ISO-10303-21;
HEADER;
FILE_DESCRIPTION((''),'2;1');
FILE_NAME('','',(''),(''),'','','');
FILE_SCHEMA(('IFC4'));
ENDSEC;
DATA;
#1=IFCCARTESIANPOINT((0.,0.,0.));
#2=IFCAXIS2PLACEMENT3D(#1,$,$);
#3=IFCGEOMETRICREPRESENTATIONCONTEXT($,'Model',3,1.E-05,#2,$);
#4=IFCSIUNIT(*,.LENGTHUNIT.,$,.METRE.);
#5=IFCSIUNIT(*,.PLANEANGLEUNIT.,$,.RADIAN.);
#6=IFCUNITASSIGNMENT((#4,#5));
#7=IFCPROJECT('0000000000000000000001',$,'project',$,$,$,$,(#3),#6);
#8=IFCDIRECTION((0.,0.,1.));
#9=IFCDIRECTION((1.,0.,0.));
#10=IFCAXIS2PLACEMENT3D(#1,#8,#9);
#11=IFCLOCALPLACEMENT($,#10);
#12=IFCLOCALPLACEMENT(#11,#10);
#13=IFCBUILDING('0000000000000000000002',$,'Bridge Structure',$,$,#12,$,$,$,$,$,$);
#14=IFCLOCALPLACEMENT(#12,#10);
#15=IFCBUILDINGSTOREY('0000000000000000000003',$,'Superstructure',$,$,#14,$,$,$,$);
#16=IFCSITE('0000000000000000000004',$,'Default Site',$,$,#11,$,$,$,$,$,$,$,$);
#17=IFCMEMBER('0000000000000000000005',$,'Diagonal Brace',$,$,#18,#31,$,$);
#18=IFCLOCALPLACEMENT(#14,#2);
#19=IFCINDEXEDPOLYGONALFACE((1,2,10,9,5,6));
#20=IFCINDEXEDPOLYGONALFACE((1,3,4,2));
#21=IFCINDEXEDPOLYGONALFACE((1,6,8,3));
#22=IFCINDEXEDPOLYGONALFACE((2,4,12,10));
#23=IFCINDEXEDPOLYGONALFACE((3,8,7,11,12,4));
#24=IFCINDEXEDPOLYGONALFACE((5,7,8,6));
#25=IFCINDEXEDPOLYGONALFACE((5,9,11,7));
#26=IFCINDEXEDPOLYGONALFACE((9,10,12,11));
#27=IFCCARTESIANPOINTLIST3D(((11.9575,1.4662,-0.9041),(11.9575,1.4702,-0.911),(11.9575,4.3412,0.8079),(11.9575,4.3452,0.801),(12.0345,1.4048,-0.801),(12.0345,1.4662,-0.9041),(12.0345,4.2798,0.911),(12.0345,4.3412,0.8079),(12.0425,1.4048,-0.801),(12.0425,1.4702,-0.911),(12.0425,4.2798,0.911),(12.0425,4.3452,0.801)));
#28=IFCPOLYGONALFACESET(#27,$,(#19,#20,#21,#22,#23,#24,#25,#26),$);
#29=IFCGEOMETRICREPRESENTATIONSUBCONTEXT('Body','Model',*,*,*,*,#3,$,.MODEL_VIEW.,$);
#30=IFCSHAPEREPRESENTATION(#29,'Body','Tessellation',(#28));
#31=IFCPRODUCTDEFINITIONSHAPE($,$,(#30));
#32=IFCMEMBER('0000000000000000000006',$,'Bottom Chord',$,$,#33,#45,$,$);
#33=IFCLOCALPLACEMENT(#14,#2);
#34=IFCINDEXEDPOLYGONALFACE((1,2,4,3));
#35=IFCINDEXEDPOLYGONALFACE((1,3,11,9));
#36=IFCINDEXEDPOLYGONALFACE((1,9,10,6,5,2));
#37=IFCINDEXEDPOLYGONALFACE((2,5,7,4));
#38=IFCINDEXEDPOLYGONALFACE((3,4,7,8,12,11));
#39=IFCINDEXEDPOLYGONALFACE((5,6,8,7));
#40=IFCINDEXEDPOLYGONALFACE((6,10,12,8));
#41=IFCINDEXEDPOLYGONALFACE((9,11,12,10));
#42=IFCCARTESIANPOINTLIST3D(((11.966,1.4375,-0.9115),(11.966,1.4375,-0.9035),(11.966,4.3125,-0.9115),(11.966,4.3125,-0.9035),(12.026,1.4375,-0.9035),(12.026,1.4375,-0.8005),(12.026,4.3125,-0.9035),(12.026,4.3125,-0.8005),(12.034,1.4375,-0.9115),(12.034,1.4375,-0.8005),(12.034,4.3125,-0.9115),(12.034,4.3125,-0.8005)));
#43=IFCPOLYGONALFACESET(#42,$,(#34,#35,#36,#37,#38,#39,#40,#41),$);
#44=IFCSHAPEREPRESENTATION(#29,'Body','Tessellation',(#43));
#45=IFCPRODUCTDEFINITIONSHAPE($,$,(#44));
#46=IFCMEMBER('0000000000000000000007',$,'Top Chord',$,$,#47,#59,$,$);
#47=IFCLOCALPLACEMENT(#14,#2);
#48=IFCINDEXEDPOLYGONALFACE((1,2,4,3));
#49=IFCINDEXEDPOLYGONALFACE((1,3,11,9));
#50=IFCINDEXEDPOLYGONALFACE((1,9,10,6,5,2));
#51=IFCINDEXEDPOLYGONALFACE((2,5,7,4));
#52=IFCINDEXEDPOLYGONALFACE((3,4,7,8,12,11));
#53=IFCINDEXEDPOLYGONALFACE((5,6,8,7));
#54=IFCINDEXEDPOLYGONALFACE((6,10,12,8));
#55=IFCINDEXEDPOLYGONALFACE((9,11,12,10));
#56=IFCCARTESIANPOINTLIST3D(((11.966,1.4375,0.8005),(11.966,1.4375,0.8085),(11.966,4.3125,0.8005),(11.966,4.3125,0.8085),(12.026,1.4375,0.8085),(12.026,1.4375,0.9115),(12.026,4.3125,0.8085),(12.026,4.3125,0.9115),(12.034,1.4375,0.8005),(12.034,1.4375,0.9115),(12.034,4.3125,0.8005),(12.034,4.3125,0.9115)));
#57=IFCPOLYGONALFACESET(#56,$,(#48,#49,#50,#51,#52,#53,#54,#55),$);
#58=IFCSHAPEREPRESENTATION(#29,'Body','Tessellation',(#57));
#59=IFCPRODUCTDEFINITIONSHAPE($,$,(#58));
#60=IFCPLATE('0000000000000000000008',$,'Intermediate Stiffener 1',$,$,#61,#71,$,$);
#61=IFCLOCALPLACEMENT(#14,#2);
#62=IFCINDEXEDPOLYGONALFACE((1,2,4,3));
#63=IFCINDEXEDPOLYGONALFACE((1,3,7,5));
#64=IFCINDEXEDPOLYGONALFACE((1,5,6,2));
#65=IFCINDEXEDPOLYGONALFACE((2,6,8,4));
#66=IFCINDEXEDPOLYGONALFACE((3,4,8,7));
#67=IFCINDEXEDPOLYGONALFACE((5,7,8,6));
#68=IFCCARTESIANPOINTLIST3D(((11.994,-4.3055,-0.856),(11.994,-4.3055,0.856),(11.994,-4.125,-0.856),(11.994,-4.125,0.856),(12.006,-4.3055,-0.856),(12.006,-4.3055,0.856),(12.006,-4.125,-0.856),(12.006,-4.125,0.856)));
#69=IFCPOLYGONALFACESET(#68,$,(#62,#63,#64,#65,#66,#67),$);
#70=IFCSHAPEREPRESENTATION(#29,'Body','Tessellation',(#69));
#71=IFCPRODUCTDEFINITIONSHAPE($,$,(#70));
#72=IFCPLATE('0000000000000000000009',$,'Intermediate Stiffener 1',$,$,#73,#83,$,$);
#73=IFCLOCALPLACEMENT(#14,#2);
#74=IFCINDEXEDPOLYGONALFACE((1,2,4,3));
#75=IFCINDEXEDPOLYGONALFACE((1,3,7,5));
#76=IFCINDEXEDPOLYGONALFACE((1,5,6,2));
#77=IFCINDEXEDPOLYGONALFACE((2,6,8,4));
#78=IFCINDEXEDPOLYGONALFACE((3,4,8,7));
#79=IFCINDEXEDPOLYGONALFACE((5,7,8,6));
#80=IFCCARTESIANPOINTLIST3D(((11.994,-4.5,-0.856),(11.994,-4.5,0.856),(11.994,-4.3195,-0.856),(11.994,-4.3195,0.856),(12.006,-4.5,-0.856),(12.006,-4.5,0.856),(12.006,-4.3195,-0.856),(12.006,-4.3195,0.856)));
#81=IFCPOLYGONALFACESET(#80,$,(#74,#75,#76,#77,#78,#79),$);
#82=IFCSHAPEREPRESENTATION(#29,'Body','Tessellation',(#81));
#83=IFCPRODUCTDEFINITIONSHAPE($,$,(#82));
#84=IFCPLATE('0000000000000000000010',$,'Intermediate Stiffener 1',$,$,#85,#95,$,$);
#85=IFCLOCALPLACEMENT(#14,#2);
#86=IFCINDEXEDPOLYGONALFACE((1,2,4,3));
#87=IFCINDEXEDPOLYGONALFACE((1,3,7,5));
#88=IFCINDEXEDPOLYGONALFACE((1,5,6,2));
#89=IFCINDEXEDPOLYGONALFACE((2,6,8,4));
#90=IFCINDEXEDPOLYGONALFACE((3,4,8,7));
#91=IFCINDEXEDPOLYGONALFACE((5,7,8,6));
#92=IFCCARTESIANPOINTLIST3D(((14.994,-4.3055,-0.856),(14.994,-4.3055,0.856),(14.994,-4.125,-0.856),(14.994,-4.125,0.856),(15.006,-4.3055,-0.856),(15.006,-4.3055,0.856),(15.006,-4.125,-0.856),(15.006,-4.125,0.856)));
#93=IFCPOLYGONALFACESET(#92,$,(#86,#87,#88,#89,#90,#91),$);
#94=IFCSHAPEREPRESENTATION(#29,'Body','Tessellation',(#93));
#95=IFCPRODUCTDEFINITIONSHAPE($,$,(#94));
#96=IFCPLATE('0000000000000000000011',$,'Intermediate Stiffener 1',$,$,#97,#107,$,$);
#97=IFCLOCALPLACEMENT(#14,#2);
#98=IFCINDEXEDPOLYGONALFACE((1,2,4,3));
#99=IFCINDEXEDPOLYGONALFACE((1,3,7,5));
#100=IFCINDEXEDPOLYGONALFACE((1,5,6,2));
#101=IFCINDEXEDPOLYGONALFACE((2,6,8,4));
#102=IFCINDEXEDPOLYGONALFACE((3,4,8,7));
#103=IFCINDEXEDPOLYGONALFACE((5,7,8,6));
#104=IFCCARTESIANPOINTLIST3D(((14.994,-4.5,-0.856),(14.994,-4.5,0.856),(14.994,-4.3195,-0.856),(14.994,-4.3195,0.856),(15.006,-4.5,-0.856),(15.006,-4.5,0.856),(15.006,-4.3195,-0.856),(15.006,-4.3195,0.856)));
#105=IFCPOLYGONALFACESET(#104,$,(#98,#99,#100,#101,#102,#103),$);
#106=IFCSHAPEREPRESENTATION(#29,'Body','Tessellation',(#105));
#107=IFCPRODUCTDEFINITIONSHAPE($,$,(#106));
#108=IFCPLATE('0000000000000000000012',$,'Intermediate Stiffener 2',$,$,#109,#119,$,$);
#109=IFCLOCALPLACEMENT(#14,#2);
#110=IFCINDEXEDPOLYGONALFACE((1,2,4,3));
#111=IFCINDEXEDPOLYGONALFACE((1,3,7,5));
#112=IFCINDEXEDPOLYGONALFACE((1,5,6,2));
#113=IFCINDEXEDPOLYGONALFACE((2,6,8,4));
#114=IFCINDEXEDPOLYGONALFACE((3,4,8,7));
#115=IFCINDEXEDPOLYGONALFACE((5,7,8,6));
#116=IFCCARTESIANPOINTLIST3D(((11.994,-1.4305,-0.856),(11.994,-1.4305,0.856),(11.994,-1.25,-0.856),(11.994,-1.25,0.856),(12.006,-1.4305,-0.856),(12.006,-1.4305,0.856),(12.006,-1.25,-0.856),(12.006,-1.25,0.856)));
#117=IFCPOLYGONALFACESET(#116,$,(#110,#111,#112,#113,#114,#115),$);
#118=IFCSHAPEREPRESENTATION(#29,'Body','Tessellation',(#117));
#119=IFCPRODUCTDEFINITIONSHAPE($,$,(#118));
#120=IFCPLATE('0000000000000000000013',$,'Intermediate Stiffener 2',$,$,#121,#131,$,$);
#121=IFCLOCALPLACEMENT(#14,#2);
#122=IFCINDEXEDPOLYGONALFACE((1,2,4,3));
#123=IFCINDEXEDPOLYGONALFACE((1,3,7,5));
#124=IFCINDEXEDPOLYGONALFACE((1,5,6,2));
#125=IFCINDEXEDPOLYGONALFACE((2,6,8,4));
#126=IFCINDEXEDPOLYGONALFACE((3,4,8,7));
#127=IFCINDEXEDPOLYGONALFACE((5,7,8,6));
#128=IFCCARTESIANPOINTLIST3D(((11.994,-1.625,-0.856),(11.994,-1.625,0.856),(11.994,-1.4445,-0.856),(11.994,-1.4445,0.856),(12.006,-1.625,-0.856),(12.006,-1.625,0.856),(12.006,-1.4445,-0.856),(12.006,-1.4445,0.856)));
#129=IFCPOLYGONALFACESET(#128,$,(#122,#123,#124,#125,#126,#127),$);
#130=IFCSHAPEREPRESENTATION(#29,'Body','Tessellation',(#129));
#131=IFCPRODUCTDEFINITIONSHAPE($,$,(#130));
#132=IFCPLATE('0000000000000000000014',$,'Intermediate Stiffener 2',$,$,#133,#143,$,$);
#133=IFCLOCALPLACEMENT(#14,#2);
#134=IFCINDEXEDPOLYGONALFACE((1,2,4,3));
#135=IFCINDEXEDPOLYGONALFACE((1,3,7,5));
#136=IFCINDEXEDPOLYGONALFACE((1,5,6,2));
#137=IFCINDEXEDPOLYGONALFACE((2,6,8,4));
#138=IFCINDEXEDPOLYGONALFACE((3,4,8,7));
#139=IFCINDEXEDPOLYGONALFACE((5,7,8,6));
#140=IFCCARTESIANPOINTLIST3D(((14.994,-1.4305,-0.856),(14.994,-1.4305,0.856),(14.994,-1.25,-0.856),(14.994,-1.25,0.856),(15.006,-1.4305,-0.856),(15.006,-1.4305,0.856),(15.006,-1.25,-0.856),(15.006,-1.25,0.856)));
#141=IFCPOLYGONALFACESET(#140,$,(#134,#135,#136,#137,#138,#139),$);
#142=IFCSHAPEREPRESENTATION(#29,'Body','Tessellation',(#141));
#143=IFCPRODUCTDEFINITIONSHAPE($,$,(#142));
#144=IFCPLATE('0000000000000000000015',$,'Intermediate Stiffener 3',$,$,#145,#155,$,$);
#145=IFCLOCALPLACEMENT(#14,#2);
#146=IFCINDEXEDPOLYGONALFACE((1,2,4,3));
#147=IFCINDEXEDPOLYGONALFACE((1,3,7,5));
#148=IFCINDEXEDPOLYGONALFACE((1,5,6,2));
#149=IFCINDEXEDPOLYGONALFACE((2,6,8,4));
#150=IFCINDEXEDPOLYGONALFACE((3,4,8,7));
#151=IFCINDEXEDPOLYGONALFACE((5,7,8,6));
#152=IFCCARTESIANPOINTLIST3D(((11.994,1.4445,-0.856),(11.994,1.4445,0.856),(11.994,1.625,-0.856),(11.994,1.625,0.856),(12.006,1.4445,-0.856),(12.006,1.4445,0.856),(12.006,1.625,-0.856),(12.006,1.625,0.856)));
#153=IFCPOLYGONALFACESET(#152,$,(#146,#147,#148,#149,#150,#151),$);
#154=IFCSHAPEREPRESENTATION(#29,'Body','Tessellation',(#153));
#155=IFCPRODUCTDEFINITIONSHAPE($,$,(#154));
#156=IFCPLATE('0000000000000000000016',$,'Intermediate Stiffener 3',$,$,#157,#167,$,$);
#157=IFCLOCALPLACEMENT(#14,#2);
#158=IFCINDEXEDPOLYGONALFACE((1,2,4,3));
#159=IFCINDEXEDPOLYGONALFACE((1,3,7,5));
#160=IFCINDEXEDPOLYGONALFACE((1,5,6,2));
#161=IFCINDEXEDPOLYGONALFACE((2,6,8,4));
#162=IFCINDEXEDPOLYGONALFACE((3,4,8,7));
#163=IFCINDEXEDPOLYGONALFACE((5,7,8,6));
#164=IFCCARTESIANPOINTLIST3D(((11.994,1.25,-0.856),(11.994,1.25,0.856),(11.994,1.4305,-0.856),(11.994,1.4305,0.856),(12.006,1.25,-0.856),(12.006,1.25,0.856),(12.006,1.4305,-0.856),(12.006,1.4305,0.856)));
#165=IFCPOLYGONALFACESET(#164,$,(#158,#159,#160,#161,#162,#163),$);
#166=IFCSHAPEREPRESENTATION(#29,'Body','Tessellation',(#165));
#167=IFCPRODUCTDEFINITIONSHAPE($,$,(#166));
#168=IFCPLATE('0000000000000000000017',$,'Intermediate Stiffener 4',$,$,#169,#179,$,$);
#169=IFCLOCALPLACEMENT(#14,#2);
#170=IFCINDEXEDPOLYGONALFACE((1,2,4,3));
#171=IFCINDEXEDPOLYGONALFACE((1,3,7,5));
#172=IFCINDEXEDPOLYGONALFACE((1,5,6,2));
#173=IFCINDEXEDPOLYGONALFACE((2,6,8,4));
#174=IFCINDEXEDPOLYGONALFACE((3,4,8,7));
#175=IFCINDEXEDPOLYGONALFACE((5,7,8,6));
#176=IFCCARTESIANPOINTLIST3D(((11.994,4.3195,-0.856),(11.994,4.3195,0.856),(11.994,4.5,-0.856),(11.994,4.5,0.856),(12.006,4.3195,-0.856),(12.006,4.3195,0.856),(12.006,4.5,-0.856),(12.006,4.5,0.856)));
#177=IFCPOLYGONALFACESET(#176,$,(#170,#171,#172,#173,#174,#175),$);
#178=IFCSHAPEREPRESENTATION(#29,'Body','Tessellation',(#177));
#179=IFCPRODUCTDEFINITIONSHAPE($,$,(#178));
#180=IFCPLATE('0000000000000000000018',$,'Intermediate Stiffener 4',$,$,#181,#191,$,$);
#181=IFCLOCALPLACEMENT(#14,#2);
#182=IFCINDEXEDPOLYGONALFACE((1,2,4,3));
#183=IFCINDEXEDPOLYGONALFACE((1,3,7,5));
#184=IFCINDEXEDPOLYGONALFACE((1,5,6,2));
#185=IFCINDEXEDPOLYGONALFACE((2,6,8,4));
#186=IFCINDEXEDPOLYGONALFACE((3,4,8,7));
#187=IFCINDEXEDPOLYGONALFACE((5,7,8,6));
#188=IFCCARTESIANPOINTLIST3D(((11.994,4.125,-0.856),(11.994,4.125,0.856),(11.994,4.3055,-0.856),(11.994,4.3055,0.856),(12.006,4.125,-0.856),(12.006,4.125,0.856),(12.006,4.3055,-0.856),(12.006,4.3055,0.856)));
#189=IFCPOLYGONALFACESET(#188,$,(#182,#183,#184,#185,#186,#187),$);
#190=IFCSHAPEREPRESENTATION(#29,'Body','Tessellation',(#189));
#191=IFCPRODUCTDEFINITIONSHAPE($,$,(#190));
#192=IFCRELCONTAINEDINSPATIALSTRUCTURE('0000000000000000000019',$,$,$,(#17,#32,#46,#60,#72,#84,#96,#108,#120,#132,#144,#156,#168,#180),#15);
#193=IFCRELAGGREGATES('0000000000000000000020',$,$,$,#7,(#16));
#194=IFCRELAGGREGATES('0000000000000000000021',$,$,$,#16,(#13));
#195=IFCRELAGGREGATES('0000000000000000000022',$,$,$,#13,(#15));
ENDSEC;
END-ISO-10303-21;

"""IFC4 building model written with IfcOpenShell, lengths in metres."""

from ifc_helpers import new_model, si_unit, frame, origin, origin_with_axes, origin_2d_with_axis, place, context, subcontext, project, spatial, rectangle, l_section, extrude, element, save


model = new_model("IFC4")

# Units and contexts
model_context = context("Model", 3, precision=1e-05, world=origin())
body_context = subcontext(model_context, "Body", "Model", "MODEL_VIEW")
ifc_project = project(units=[si_unit("LENGTHUNIT", "METRE"), si_unit("PLANEANGLEUNIT", "RADIAN")], contexts=[model_context])

# Site, building, storey
site_placement = place(None, origin_with_axes())
site = spatial("IfcSite", under=ifc_project, at=site_placement, Name="Default Site")
building_placement = place(site_placement, origin_with_axes())
building = spatial("IfcBuilding", under=site, at=building_placement, Name="Bridge Structure")
storey_placement = place(building_placement, origin_with_axes())
storey = spatial("IfcBuildingStorey", under=building, at=storey_placement, Name="Superstructure")

# Members
for number, where, z_axis, x_axis, name in (
    (1, (12.0, 1.4375, -0.856), (0.0, 0.859202, 0.511636), (-1.0, 0.0, 0.0), "Diagonal Brace"),
):
    element("IfcMember", number, at=place(storey_placement, frame(where, z_axis=z_axis, x_axis=x_axis)), inside=storey, Name=name, context=body_context, shape_type="SweptSolid", body=[
        extrude(l_section(Depth=0.128, Width=0.085, Thickness=0.008, at=origin_2d_with_axis()), origin_with_axes(), (0.0, 0.0, 1.0), 3.3461),
    ])
for number, where, z_axis, x_axis, name in (
    (2, (12.0, 1.4375, -0.856), (0.0, 1.0, 0.0), (-1.0, 0.0, 0.0), "Bottom Chord"),
    (3, (12.0, 1.4375, 0.856), (0.0, 1.0, 0.0), (-1.0, 0.0, 0.0), "Top Chord"),
):
    element("IfcMember", number, at=place(storey_placement, frame(where, z_axis=z_axis, x_axis=x_axis)), inside=storey, Name=name, context=body_context, shape_type="SweptSolid", body=[
        extrude(l_section(Depth=0.111, Width=0.068, Thickness=0.008, at=origin_2d_with_axis()), origin_with_axes(), (0.0, 0.0, 1.0), 2.875),
    ])

# Plates
for number, where, z_axis, x_axis, name in (
    (4, (12.0, -4.2153, -0.856), (0.0, 0.0, 1.0), (1.0, 0.0, 0.0), "Intermediate Stiffener 1"),
    (5, (12.0, -4.4097, -0.856), (0.0, 0.0, 1.0), (1.0, 0.0, 0.0), "Intermediate Stiffener 1"),
    (6, (15.0, -4.2153, -0.856), (0.0, 0.0, 1.0), (1.0, 0.0, 0.0), "Intermediate Stiffener 1"),
    (7, (15.0, -4.4097, -0.856), (0.0, 0.0, 1.0), (1.0, 0.0, 0.0), "Intermediate Stiffener 1"),
    (8, (12.0, -1.3402, -0.856), (0.0, 0.0, 1.0), (1.0, 0.0, 0.0), "Intermediate Stiffener 2"),
    (9, (12.0, -1.5348, -0.856), (0.0, 0.0, 1.0), (1.0, 0.0, 0.0), "Intermediate Stiffener 2"),
    (10, (15.0, -1.3402, -0.856), (0.0, 0.0, 1.0), (1.0, 0.0, 0.0), "Intermediate Stiffener 2"),
    (11, (12.0, 1.5348, -0.856), (0.0, 0.0, 1.0), (1.0, 0.0, 0.0), "Intermediate Stiffener 3"),
    (12, (12.0, 1.3402, -0.856), (0.0, 0.0, 1.0), (1.0, 0.0, 0.0), "Intermediate Stiffener 3"),
    (13, (12.0, 4.4097, -0.856), (0.0, 0.0, 1.0), (1.0, 0.0, 0.0), "Intermediate Stiffener 4"),
    (14, (12.0, 4.2153, -0.856), (0.0, 0.0, 1.0), (1.0, 0.0, 0.0), "Intermediate Stiffener 4"),
):
    element("IfcPlate", number, at=place(storey_placement, frame(where, z_axis=z_axis, x_axis=x_axis)), inside=storey, Name=name, context=body_context, shape_type="SweptSolid", body=[
        extrude(rectangle(XDim=0.012, YDim=0.1805, at=origin_2d_with_axis()), origin_with_axes(), (0.0, 0.0, 1.0), 1.712),
    ])

save(model, "model.ifc")
